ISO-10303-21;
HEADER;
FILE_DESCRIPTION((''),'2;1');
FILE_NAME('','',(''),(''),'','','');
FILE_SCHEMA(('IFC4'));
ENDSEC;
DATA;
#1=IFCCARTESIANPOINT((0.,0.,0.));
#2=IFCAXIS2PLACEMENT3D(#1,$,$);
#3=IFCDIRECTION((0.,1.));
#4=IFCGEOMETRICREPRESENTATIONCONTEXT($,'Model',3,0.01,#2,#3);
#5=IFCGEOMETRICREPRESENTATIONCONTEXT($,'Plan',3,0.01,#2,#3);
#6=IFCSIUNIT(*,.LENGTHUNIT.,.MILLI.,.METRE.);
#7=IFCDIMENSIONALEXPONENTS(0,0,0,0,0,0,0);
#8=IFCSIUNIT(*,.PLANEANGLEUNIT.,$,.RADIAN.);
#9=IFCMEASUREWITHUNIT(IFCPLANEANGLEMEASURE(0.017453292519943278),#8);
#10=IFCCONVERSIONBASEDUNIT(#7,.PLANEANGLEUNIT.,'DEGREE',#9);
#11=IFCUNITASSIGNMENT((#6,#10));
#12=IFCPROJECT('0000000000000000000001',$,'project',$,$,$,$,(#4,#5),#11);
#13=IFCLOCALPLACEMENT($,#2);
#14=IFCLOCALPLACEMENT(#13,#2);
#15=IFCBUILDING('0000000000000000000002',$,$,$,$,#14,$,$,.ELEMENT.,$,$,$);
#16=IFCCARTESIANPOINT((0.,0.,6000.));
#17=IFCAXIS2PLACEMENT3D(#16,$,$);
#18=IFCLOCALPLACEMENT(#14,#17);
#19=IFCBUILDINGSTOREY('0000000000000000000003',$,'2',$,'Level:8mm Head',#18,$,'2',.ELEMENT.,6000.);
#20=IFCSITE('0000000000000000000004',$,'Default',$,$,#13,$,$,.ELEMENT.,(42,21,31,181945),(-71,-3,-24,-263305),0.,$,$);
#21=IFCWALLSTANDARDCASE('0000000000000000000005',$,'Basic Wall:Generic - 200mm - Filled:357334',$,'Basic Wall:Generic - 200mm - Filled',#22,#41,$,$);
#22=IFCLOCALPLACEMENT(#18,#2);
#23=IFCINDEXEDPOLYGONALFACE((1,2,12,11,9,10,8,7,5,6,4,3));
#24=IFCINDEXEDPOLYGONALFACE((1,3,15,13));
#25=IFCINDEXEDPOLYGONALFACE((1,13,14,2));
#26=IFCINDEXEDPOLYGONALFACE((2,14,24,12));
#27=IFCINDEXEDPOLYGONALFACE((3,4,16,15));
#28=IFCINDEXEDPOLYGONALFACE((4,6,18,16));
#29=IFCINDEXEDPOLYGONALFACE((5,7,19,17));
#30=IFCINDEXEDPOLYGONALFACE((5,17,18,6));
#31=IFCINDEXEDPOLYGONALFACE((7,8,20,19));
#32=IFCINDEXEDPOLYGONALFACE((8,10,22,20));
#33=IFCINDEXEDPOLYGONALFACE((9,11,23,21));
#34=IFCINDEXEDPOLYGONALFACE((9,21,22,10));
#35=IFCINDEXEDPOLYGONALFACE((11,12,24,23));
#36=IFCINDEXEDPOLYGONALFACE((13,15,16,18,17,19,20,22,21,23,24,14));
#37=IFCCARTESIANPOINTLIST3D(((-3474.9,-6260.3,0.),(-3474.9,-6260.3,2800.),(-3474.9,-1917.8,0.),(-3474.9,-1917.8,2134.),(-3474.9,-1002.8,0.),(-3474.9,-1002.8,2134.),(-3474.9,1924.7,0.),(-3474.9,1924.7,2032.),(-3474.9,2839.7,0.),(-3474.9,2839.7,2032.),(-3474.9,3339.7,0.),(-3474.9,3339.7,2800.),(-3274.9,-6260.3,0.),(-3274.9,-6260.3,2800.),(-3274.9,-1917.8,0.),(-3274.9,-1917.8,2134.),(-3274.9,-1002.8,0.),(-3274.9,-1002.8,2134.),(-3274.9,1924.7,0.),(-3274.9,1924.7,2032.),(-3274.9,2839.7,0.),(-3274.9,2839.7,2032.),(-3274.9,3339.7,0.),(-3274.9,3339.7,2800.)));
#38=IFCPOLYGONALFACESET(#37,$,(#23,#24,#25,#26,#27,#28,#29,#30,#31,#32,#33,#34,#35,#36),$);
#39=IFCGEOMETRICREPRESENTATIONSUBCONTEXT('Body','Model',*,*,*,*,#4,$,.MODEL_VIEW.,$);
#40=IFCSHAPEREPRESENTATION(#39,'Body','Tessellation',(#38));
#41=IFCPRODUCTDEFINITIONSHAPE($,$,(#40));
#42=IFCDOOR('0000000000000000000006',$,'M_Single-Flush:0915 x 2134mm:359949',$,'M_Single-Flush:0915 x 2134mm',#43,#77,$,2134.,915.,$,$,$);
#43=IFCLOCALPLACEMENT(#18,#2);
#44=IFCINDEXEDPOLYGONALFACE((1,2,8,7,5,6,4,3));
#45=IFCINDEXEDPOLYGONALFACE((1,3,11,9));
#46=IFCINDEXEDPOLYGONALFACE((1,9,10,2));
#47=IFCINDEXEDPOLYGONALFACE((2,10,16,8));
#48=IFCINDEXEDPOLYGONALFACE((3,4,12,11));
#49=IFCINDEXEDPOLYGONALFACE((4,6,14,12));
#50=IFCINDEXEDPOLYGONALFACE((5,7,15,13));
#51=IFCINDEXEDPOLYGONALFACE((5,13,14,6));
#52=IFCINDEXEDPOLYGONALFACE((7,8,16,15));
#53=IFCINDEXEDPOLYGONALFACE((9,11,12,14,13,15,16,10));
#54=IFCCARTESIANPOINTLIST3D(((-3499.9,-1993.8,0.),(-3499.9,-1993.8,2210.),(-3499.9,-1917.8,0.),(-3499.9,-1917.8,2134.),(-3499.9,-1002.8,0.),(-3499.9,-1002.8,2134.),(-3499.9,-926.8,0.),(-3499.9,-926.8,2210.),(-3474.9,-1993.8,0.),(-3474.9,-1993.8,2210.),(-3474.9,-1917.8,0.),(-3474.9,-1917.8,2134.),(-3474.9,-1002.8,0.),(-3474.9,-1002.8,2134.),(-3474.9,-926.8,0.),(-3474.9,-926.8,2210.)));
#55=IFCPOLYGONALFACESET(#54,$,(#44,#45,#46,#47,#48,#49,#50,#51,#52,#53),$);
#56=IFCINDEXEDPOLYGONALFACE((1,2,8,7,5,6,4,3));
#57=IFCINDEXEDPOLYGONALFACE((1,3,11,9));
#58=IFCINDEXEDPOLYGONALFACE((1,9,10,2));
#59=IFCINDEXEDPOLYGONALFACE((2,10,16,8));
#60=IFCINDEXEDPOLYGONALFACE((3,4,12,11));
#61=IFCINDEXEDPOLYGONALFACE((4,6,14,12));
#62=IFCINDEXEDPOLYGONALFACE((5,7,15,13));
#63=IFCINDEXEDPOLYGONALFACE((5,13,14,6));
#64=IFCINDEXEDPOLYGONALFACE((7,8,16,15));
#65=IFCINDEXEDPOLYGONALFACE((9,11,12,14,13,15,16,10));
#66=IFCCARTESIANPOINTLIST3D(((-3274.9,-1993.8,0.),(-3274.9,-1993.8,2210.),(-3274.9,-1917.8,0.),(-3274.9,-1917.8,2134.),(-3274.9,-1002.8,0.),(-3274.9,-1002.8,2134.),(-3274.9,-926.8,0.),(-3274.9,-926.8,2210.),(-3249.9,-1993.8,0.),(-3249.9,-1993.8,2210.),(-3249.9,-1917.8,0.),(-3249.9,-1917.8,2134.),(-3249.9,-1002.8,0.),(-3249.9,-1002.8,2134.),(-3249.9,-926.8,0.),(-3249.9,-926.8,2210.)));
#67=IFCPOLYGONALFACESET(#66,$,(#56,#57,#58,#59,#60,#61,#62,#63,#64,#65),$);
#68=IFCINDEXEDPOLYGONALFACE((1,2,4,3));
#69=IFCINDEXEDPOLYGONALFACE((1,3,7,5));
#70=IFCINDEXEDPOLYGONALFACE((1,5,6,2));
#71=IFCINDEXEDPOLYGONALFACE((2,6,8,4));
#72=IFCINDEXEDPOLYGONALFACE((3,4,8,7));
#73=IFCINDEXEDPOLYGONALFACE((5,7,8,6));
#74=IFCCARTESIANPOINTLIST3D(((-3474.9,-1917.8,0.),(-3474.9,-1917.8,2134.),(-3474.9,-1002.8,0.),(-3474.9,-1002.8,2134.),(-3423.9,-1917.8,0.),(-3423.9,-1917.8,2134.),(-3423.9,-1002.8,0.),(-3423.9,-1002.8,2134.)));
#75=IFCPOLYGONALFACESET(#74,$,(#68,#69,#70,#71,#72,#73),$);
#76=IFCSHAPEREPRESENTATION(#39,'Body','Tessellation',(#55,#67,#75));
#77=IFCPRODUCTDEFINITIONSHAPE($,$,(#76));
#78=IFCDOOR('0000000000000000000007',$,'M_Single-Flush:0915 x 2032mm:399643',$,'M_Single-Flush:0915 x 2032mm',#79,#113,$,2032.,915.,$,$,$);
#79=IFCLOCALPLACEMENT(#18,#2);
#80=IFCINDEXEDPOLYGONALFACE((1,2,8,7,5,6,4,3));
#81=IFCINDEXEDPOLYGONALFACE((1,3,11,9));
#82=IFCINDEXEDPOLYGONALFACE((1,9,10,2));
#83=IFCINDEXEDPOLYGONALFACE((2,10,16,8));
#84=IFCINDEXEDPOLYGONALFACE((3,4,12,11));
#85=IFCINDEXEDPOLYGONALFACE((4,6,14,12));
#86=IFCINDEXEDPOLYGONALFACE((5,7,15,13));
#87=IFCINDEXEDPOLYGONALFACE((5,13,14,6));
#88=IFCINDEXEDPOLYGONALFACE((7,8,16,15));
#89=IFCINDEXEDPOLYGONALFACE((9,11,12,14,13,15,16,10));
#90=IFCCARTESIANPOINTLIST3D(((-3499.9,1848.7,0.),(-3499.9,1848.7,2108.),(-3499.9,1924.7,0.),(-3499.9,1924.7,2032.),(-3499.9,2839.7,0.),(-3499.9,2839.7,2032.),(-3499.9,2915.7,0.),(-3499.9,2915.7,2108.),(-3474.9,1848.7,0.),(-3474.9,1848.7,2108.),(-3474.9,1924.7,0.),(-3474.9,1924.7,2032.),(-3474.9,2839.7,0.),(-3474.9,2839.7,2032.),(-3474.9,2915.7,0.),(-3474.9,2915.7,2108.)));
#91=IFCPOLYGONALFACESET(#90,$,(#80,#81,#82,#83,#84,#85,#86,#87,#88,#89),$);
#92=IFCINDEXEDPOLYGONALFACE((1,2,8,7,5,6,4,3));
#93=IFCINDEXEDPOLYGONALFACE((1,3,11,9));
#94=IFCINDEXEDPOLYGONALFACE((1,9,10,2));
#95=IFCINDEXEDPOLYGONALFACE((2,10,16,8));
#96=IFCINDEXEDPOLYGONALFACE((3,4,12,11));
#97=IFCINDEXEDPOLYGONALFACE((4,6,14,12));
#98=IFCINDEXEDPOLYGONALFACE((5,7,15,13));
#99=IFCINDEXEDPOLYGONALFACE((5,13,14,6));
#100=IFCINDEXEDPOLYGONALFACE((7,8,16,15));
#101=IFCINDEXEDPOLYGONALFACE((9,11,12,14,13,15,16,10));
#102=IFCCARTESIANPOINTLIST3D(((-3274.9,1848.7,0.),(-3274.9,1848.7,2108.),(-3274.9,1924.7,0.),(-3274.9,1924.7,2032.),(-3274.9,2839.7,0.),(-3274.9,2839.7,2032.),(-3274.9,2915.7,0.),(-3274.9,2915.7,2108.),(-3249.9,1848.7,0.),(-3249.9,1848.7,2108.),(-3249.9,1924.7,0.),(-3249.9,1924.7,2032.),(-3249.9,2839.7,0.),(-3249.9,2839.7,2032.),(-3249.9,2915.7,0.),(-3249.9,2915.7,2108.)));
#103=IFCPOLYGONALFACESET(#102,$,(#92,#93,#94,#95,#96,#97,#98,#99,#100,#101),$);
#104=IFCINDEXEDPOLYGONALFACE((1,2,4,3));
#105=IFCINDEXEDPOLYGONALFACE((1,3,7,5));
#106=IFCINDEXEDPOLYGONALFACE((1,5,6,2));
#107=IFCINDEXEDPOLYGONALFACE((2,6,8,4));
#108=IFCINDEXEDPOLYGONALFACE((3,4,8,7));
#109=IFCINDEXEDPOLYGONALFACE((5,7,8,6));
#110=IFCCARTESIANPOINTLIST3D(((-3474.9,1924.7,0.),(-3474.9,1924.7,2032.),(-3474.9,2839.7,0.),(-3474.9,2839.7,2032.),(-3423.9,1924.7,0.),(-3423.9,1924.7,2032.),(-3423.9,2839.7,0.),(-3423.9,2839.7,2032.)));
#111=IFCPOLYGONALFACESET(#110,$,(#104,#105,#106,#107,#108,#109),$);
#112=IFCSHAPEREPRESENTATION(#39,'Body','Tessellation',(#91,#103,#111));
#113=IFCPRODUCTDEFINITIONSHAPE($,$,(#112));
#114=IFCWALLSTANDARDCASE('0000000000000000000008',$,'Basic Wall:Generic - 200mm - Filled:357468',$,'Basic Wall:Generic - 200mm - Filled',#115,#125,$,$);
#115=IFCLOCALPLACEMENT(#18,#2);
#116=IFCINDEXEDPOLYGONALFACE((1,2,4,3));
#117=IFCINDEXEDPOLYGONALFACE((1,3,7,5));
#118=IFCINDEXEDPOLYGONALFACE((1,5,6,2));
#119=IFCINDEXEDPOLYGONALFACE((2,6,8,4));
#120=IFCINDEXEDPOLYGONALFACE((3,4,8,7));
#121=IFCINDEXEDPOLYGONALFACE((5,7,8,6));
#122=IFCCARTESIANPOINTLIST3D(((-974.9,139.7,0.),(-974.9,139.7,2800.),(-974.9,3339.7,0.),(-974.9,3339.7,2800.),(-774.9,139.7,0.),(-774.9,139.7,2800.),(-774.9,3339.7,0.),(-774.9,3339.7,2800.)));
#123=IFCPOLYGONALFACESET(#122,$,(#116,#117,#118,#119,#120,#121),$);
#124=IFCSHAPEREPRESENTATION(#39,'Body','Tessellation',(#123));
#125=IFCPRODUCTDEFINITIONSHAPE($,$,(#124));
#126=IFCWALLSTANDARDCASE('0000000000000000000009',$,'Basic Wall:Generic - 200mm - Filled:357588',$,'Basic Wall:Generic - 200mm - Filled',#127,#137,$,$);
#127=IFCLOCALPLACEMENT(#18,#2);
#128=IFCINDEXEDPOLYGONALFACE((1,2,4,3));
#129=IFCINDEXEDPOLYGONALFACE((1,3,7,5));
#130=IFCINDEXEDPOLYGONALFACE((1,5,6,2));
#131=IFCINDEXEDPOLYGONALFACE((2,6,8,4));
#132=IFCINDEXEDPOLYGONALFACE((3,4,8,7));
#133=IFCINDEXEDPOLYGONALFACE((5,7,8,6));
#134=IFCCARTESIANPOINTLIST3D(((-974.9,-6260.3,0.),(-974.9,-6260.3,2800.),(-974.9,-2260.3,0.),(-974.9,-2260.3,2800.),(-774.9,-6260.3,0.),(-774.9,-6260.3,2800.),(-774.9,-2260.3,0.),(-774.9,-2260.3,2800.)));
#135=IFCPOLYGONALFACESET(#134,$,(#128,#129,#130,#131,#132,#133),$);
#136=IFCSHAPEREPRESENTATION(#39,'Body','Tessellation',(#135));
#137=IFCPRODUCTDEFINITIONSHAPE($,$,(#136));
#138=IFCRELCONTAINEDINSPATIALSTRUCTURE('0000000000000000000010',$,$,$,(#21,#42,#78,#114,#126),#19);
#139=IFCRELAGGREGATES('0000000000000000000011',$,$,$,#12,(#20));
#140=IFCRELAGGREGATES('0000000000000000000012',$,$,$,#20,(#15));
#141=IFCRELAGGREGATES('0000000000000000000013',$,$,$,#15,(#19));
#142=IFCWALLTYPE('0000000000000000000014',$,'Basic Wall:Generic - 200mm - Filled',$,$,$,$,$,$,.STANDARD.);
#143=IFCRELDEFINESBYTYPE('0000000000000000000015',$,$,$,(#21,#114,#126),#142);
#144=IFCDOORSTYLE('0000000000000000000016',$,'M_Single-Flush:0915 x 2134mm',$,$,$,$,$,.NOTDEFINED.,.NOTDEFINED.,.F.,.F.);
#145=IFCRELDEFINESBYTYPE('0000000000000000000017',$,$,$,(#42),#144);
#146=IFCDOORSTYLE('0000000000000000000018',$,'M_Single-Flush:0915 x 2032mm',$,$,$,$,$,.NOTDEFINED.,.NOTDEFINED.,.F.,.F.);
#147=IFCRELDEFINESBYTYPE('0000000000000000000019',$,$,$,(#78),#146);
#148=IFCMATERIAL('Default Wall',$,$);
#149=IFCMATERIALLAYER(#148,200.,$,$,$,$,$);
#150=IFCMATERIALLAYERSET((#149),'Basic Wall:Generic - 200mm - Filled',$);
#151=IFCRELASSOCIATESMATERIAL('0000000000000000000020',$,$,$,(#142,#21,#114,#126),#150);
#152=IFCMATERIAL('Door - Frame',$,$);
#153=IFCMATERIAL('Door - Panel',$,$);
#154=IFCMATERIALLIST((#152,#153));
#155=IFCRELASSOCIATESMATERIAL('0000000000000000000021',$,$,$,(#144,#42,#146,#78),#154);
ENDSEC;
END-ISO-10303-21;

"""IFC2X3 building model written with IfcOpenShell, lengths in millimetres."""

from ifc_helpers import new_model, entity, si_unit, converted_unit, direction, frame, frame_2d, origin, place, context, subcontext, project, spatial, polyline, rectangle, outline, extrude, source, transform, mapped, material, material_list, layer, layer_set, layer_usage, type_object, type_shapes, element, fill, save


model = new_model("IFC2X3")

# Units and contexts
model_context = context("Model", 3, precision=0.01, world=origin(), true_north=direction((0.0, 1.0)))
plan_context = context("Plan", 3, precision=0.01, world=origin(), true_north=direction((0.0, 1.0)))
body_context = subcontext(model_context, "Body", "Model", "MODEL_VIEW")
ifc_project = project(units=[si_unit("LENGTHUNIT", "METRE", prefix="MILLI"), converted_unit("PLANEANGLEUNIT", "DEGREE", entity("IfcPlaneAngleMeasure", 0.017453292519943278), si_unit("PLANEANGLEUNIT", "RADIAN"), dimensions=[0, 0, 0, 0, 0, 0, 0])], contexts=[model_context, plan_context])

# Site, building, storey
site_placement = place(None, origin())
site = spatial("IfcSite", under=ifc_project, at=site_placement, Name="Default", CompositionType="ELEMENT", RefLatitude=(42, 21, 31, 181945), RefLongitude=(-71, -3, -24, -263305), RefElevation=0.0)
building_placement = place(site_placement, origin())
building = spatial("IfcBuilding", under=site, at=building_placement, CompositionType="ELEMENT")
storey_placement = place(building_placement, frame((0.0, 0.0, 6000.0)))
storey = spatial("IfcBuildingStorey", under=building, at=storey_placement, Name="2", ObjectType="Level:8mm Head", LongName="2", CompositionType="ELEMENT", Elevation=6000.0)

# Wall, openings, doors
ifc_material_1 = material(Name="Default Wall")
ifc_layer_1 = layer(ifc_material_1, 200.0)
ifc_layer_set_1 = layer_set([ifc_layer_1], Name="Basic Wall:Generic - 200mm - Filled")
ifc_layer_usage_1 = layer_usage(ifc_layer_set_1, "AXIS2", "NEGATIVE", 100.0)
wall_type_1 = type_object("IfcWallType", Name="Basic Wall:Generic - 200mm - Filled", PredefinedType="STANDARD", material=ifc_layer_set_1)
wall_1_placement = place(storey_placement, frame((-3374.9, 3339.7, 0.0), z_axis=(0.0, 0.0, 1.0), x_axis=(0.0, -1.0, 0.0)))
wall_1 = element("IfcWallStandardCase", 1, at=wall_1_placement, inside=storey, type_object=wall_type_1, material=ifc_layer_usage_1, Name="Basic Wall:Generic - 200mm - Filled:357334", ObjectType="Basic Wall:Generic - 200mm - Filled", context=body_context, shape_type="SweptSolid", body=[
    extrude(rectangle(XDim=9600.0, YDim=200.0, at=frame_2d((4800.0, 0.0), x_axis=(1.0, 0.0))), origin(), (0.0, 0.0, 1.0), 2800.0),
])
opening_1_placement = place(wall_1_placement, frame((5257.5, 100.0, 0.0)))
opening_1 = element("IfcOpeningElement", 2, at=opening_1_placement, cuts=wall_1, ObjectType="Opening", context=body_context, shape_type="SweptSolid", body=[
    extrude(rectangle(XDim=915.0, YDim=2134.0, at=frame_2d((1067.0, 457.5), x_axis=(0.0, 1.0))), frame((0.0, 0.0, 0.0), z_axis=(0.0, -1.0, 0.0), x_axis=(0.0, 0.0, 1.0)), (0.0, 0.0, 1.0), 200.0),
])
opening_2_placement = place(wall_1_placement, frame((1415.0, 100.0, 0.0)))
opening_2 = element("IfcOpeningElement", 3, at=opening_2_placement, cuts=wall_1, ObjectType="Opening", context=body_context, shape_type="SweptSolid", body=[
    extrude(rectangle(XDim=915.0, YDim=2032.0, at=frame_2d((1016.0, 457.5), x_axis=(0.0, 1.0))), frame((0.0, 0.0, 0.0), z_axis=(0.0, -1.0, 0.0), x_axis=(0.0, 0.0, 1.0)), (0.0, 0.0, 1.0), 200.0),
])
ifc_material_2 = material(Name="Door - Frame")
ifc_material_3 = material(Name="Door - Panel")
ifc_material_list = material_list([ifc_material_2, ifc_material_3])
door_style_1 = type_object("IfcDoorStyle", Name="M_Single-Flush:0915 x 2134mm", ConstructionType="NOTDEFINED", OperationType="NOTDEFINED", ParameterTakesPrecedence=False, Sizeable=False, material=ifc_material_list)
shared_shape_1 = source(origin(), body_context, "Body", "SweptSolid", [
    extrude(outline(polyline([(-533.5, -1124.0), (533.5, -1124.0), (533.5, 1086.0), (457.5, 1086.0), (457.5, -1048.0), (-457.5, -1048.0), (-457.5, 1086.0), (-533.5, 1086.0), (-533.5, -1124.0)])), frame((457.5, 200.0, 1086.0), z_axis=(0.0, 1.0, 0.0), x_axis=(1.0, 0.0, 0.0)), (0.0, 0.0, 1.0), 25.0),
    extrude(outline(polyline([(-1124.0, -533.5), (1086.0, -533.5), (1086.0, -457.5), (-1048.0, -457.5), (-1048.0, 457.5), (1086.0, 457.5), (1086.0, 533.5), (-1124.0, 533.5), (-1124.0, -533.5)])), frame((457.5, -25.0, 1086.0), z_axis=(0.0, 1.0, 0.0), x_axis=(0.0, 0.0, -1.0)), (0.0, 0.0, 1.0), 25.0),
    extrude(rectangle(XDim=51.0, YDim=915.0, at=frame_2d((0.0, 0.0), x_axis=(1.0, 0.0))), frame((457.5, 174.5, 0.0), z_axis=(0.0, 0.0, 1.0), x_axis=(0.0, 1.0, 0.0)), (0.0, 0.0, 1.0), 2134.0),
])
type_shapes(door_style_1, [shared_shape_1])
door_1_placement = place(opening_1_placement, frame((0.0, 0.0, 0.0), z_axis=(0.0, 0.0, 1.0), x_axis=(-1.0, 0.0, 0.0)))
door_1 = element("IfcDoor", 4, at=door_1_placement, inside=storey, type_object=door_style_1, material=ifc_material_list, Name="M_Single-Flush:0915 x 2134mm:359949", ObjectType="M_Single-Flush:0915 x 2134mm", OverallHeight=2134.0, OverallWidth=915.0, context=body_context, shape_type="MappedRepresentation", body=[
    mapped(shared_shape_1, transform((0.0, 0.0, 0.0), scale=1.0)),
])
fill(opening_1, door_1)
door_style_2 = type_object("IfcDoorStyle", Name="M_Single-Flush:0915 x 2032mm", ConstructionType="NOTDEFINED", OperationType="NOTDEFINED", ParameterTakesPrecedence=False, Sizeable=False, material=ifc_material_list)
shared_shape_2 = source(origin(), body_context, "Body", "SweptSolid", [
    extrude(outline(polyline([(-533.5, -1073.0), (533.5, -1073.0), (533.5, 1035.0), (457.5, 1035.0), (457.5, -997.0), (-457.5, -997.0), (-457.5, 1035.0), (-533.5, 1035.0), (-533.5, -1073.0)])), frame((457.5, 200.0, 1035.0), z_axis=(0.0, 1.0, 0.0), x_axis=(1.0, 0.0, 0.0)), (0.0, 0.0, 1.0), 25.0),
    extrude(outline(polyline([(-1073.0, -533.5), (1035.0, -533.5), (1035.0, -457.5), (-997.0, -457.5), (-997.0, 457.5), (1035.0, 457.5), (1035.0, 533.5), (-1073.0, 533.5), (-1073.0, -533.5)])), frame((457.5, -25.0, 1035.0), z_axis=(0.0, 1.0, 0.0), x_axis=(0.0, 0.0, -1.0)), (0.0, 0.0, 1.0), 25.0),
    extrude(rectangle(XDim=51.0, YDim=915.0, at=frame_2d((0.0, 0.0), x_axis=(1.0, 0.0))), frame((457.5, 174.5, 0.0), z_axis=(0.0, 0.0, 1.0), x_axis=(0.0, 1.0, 0.0)), (0.0, 0.0, 1.0), 2032.0),
])
type_shapes(door_style_2, [shared_shape_2])
door_2_placement = place(opening_2_placement, frame((0.0, 0.0, 0.0), z_axis=(0.0, 0.0, 1.0), x_axis=(-1.0, 0.0, 0.0)))
door_2 = element("IfcDoor", 5, at=door_2_placement, inside=storey, type_object=door_style_2, material=ifc_material_list, Name="M_Single-Flush:0915 x 2032mm:399643", ObjectType="M_Single-Flush:0915 x 2032mm", OverallHeight=2032.0, OverallWidth=915.0, context=body_context, shape_type="MappedRepresentation", body=[
    mapped(shared_shape_2, transform((0.0, 0.0, 0.0), scale=1.0)),
])
fill(opening_2, door_2)

# Walls
wall_2_placement = place(storey_placement, frame((-874.9, 3339.7, 0.0), z_axis=(0.0, 0.0, 1.0), x_axis=(0.0, -1.0, 0.0)))
element("IfcWallStandardCase", 6, at=wall_2_placement, inside=storey, type_object=wall_type_1, material=ifc_layer_usage_1, Name="Basic Wall:Generic - 200mm - Filled:357468", ObjectType="Basic Wall:Generic - 200mm - Filled", context=body_context, shape_type="SweptSolid", body=[
    extrude(rectangle(XDim=3200.0, YDim=200.0, at=frame_2d((1600.0, 0.0), x_axis=(-1.0, 0.0))), origin(), (0.0, 0.0, 1.0), 2800.0),
])
wall_3_placement = place(storey_placement, frame((-874.9, -2260.3, 0.0), z_axis=(0.0, 0.0, 1.0), x_axis=(0.0, -1.0, 0.0)))
element("IfcWallStandardCase", 7, at=wall_3_placement, inside=storey, type_object=wall_type_1, material=ifc_layer_usage_1, Name="Basic Wall:Generic - 200mm - Filled:357588", ObjectType="Basic Wall:Generic - 200mm - Filled", context=body_context, shape_type="SweptSolid", body=[
    extrude(rectangle(XDim=4000.0, YDim=200.0, at=frame_2d((2000.0, 0.0), x_axis=(-1.0, 0.0))), origin(), (0.0, 0.0, 1.0), 2800.0),
])

save(model, "model.ifc")
